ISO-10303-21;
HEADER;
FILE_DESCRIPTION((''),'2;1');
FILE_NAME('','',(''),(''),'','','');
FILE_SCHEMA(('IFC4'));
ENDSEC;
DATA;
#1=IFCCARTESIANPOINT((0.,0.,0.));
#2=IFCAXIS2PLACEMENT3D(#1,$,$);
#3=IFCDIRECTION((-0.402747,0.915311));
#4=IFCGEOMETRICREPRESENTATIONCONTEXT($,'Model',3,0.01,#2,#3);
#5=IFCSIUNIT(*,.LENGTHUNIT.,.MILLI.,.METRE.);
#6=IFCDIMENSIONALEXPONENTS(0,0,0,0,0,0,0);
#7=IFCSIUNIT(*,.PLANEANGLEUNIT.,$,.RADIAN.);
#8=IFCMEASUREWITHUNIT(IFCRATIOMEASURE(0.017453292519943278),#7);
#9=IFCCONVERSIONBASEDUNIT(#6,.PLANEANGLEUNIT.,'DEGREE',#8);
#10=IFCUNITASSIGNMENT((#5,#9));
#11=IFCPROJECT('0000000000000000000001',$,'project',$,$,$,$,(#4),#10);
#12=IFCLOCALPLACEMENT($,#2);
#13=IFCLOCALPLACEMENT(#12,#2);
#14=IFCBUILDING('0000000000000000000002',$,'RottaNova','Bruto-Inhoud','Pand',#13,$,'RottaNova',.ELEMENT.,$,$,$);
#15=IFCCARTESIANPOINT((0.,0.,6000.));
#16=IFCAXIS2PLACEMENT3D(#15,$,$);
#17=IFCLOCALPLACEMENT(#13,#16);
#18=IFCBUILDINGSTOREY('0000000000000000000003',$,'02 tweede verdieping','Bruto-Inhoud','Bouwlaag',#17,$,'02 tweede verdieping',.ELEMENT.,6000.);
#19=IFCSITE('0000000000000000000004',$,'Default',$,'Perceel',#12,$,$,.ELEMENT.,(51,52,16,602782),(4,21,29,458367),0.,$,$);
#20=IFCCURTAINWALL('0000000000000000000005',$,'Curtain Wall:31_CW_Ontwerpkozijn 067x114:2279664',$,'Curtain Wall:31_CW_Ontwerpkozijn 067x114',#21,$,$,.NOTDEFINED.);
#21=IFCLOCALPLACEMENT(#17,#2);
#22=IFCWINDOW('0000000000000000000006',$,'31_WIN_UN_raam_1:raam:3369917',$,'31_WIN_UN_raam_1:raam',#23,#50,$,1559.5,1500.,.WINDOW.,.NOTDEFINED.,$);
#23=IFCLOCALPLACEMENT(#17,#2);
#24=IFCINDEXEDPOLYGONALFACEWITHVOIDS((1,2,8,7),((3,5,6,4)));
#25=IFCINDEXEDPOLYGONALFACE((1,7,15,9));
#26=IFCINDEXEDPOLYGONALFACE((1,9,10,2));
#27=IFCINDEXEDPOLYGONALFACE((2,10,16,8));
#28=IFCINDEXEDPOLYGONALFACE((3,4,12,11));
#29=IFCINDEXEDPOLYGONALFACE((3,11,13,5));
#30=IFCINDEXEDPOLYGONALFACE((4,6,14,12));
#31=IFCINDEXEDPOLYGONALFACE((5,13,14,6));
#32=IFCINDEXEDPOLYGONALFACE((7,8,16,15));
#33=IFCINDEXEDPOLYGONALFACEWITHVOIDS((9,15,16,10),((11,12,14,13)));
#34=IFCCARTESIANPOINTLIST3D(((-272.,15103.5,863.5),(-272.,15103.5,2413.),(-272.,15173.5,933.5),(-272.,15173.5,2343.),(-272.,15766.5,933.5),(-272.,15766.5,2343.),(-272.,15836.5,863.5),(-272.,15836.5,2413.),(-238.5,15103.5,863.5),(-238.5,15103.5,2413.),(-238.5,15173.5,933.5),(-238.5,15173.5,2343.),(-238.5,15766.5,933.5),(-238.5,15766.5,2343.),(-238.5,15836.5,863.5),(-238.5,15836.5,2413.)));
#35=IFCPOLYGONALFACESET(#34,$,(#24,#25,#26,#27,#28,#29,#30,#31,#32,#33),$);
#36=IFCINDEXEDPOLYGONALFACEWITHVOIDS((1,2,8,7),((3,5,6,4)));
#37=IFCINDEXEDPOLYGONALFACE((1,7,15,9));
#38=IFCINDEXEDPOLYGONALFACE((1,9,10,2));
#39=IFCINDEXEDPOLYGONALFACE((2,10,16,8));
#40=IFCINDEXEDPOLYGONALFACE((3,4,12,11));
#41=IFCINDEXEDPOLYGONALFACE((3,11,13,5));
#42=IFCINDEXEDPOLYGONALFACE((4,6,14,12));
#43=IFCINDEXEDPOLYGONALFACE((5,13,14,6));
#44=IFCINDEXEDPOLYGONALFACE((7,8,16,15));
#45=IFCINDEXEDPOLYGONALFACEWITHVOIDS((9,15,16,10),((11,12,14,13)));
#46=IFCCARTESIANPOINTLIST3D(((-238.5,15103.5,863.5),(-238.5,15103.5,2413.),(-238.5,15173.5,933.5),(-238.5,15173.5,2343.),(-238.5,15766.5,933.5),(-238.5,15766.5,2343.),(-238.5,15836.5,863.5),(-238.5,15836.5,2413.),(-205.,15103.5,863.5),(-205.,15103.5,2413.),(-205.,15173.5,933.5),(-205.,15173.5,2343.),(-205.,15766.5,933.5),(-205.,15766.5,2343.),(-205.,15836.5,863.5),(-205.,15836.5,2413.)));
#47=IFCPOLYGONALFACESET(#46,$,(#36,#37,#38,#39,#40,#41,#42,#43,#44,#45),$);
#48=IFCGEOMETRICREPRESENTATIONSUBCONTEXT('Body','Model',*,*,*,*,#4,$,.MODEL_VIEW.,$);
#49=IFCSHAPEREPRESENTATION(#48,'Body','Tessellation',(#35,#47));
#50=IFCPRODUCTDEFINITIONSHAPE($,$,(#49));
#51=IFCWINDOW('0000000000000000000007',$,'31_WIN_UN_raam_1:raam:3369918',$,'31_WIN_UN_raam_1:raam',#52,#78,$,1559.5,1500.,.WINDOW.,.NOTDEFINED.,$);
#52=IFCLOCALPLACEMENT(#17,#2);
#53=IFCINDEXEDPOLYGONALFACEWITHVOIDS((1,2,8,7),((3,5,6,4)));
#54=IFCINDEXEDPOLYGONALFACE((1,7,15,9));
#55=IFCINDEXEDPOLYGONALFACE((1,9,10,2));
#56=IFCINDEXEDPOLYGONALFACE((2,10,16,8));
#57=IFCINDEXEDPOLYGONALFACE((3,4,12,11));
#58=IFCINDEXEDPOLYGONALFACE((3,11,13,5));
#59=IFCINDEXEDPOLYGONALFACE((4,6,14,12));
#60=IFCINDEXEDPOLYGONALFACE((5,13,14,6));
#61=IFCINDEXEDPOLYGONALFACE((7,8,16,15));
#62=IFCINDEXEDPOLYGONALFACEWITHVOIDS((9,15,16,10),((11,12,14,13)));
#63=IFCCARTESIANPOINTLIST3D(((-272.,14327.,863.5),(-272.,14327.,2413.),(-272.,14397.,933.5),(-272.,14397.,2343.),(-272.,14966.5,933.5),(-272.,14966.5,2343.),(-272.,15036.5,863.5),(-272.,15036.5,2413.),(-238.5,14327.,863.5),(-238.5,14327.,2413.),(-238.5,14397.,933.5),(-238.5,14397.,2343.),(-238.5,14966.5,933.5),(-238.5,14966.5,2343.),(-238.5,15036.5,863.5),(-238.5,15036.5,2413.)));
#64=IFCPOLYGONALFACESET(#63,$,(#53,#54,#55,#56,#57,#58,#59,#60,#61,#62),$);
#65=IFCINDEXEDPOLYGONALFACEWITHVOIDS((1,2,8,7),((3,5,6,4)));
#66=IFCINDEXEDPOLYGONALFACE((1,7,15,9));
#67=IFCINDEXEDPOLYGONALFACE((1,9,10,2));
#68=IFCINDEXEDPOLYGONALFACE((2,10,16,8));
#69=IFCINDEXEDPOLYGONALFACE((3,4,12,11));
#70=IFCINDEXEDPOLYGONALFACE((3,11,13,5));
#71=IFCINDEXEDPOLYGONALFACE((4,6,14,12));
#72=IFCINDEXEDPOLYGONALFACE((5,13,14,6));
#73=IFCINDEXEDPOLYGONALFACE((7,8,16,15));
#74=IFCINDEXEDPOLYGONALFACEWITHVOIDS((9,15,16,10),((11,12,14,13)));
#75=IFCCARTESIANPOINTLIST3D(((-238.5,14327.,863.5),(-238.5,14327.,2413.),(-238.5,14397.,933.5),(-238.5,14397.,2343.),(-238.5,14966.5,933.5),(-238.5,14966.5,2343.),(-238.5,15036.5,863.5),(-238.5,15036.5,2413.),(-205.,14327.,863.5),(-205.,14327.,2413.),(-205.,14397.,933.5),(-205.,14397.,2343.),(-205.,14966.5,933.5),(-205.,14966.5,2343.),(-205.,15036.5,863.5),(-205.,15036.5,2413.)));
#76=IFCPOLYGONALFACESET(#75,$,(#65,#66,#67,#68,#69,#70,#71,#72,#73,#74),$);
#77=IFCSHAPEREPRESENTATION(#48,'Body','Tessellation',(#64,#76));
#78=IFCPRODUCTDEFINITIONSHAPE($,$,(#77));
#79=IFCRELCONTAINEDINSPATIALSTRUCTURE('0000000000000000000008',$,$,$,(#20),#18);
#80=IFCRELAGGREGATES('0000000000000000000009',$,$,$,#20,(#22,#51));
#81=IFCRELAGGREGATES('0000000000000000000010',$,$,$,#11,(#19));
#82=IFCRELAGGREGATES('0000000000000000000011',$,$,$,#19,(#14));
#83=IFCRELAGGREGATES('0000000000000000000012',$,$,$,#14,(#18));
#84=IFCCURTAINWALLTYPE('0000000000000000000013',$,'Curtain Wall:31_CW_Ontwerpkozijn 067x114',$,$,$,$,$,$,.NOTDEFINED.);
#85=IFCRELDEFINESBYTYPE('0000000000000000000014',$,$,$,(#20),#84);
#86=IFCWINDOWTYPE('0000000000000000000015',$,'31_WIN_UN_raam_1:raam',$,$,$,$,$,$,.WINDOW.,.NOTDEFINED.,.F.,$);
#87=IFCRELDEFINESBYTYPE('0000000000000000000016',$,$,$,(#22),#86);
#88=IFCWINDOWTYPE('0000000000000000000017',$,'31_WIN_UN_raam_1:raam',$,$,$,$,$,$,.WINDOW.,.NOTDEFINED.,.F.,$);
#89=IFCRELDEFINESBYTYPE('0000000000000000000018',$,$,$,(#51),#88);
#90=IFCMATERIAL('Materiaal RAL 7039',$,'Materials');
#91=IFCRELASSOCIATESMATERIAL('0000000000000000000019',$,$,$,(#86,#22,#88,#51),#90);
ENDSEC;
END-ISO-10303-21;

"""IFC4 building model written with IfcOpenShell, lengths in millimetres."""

from ifc_helpers import new_model, entity, si_unit, converted_unit, direction, frame, origin, place, context, subcontext, project, spatial, polyline, outline, extrude, source, transform, mapped, material, type_object, type_shapes, element, aggregate, save


model = new_model("IFC4")

# Units and contexts
model_context = context("Model", 3, precision=0.01, world=origin(), true_north=direction((-0.402747, 0.915311)))
body_context = subcontext(model_context, "Body", "Model", "MODEL_VIEW")
ifc_project = project(units=[si_unit("LENGTHUNIT", "METRE", prefix="MILLI"), converted_unit("PLANEANGLEUNIT", "DEGREE", entity("IfcRatioMeasure", 0.017453292519943278), si_unit("PLANEANGLEUNIT", "RADIAN"), dimensions=[0, 0, 0, 0, 0, 0, 0])], contexts=[model_context])

# Site, building, storey
site_placement = place(None, origin())
site = spatial("IfcSite", under=ifc_project, at=site_placement, Name="Default", ObjectType="Perceel", CompositionType="ELEMENT", RefLatitude=(51, 52, 16, 602782), RefLongitude=(4, 21, 29, 458367), RefElevation=0.0)
building_placement = place(site_placement, origin())
building = spatial("IfcBuilding", under=site, at=building_placement, Name="RottaNova", Description="Bruto-Inhoud", ObjectType="Pand", LongName="RottaNova", CompositionType="ELEMENT")
storey_placement = place(building_placement, frame((0.0, 0.0, 6000.0)))
storey = spatial("IfcBuildingStorey", under=building, at=storey_placement, Name="02 tweede verdieping", Description="Bruto-Inhoud", ObjectType="Bouwlaag", LongName="02 tweede verdieping", CompositionType="ELEMENT", Elevation=6000.0)

# Curtain wall
curtain_wall_type = type_object("IfcCurtainWallType", Name="Curtain Wall:31_CW_Ontwerpkozijn 067x114", PredefinedType="NOTDEFINED")
curtain_wall_placement = place(storey_placement, frame((0.0, 0.0, -6000.0)))
curtain_wall = element("IfcCurtainWall", 1, at=curtain_wall_placement, inside=storey, type_object=curtain_wall_type, Name="Curtain Wall:31_CW_Ontwerpkozijn 067x114:2279664", ObjectType="Curtain Wall:31_CW_Ontwerpkozijn 067x114", PredefinedType="NOTDEFINED")

# Windows
ifc_material_1 = material(Name="Materiaal RAL 7039", Category="Materials")
window_type_1 = type_object("IfcWindowType", Name="31_WIN_UN_raam_1:raam", ParameterTakesPrecedence=False, PartitioningType="NOTDEFINED", PredefinedType="WINDOW", material=ifc_material_1)
shared_shape_1 = source(origin(), body_context, "Body", "SweptSolid", [
    extrude(outline(polyline([(-366.5, -774.7), (366.5, -774.7), (366.5, 774.7), (-366.5, 774.7), (-366.5, -774.7)]), holes=[polyline([(-296.5, 704.7), (296.5, 704.7), (296.5, -704.8), (-296.5, -704.8), (-296.5, 704.7)])]), frame((0.0, 92.0, 774.8), z_axis=(0.0, -1.0, 0.0), x_axis=(-1.0, 0.0, 0.0)), (0.0, 0.0, 1.0), 33.5),
    extrude(outline(polyline([(-366.5, -774.7), (366.5, -774.7), (366.5, 774.7), (-366.5, 774.7), (-366.5, -774.7)]), holes=[polyline([(-296.5, 704.7), (296.5, 704.7), (296.5, -704.8), (-296.5, -704.8), (-296.5, 704.7)])]), frame((0.0, 58.5, 774.8), z_axis=(0.0, -1.0, 0.0), x_axis=(-1.0, 0.0, 0.0)), (0.0, 0.0, 1.0), 33.5),
])
type_shapes(window_type_1, [shared_shape_1])
window_1_placement = place(curtain_wall_placement, frame((-180.0, 15470.0, 6863.5), z_axis=(0.0, 0.0, 1.0), x_axis=(0.0, 1.0, 0.0)))
window_1 = element("IfcWindow", 2, at=window_1_placement, type_object=window_type_1, material=ifc_material_1, Name="31_WIN_UN_raam_1:raam:3369917", ObjectType="31_WIN_UN_raam_1:raam", OverallHeight=1559.5, OverallWidth=1500.0, PartitioningType="NOTDEFINED", PredefinedType="WINDOW", context=body_context, shape_type="MappedRepresentation", body=[
    mapped(shared_shape_1, transform((0.0, 0.0, 0.0), scale=1.0)),
])
window_type_2 = type_object("IfcWindowType", Name="31_WIN_UN_raam_1:raam", ParameterTakesPrecedence=False, PartitioningType="NOTDEFINED", PredefinedType="WINDOW", material=ifc_material_1)
shared_shape_2 = source(origin(), body_context, "Body", "SweptSolid", [
    extrude(outline(polyline([(-354.7, -774.7), (354.7, -774.7), (354.7, 774.7), (-354.7, 774.7), (-354.7, -774.7)]), holes=[polyline([(-284.7, 704.7), (284.7, 704.7), (284.7, -704.8), (-284.7, -704.8), (-284.7, 704.7)])]), frame((0.0, 92.0, 774.8), z_axis=(0.0, -1.0, 0.0), x_axis=(-1.0, 0.0, 0.0)), (0.0, 0.0, 1.0), 33.5),
    extrude(outline(polyline([(-354.7, -774.7), (354.7, -774.7), (354.7, 774.7), (-354.7, 774.7), (-354.7, -774.7)]), holes=[polyline([(-284.7, 704.7), (284.7, 704.7), (284.7, -704.8), (-284.7, -704.8), (-284.7, 704.7)])]), frame((0.0, 58.5, 774.8), z_axis=(0.0, -1.0, 0.0), x_axis=(-1.0, 0.0, 0.0)), (0.0, 0.0, 1.0), 33.5),
])
type_shapes(window_type_2, [shared_shape_2])
window_2_placement = place(curtain_wall_placement, frame((-180.0, 14681.8, 6863.5), z_axis=(0.0, 0.0, 1.0), x_axis=(0.0, 1.0, 0.0)))
window_2 = element("IfcWindow", 3, at=window_2_placement, type_object=window_type_2, material=ifc_material_1, Name="31_WIN_UN_raam_1:raam:3369918", ObjectType="31_WIN_UN_raam_1:raam", OverallHeight=1559.5, OverallWidth=1500.0, PartitioningType="NOTDEFINED", PredefinedType="WINDOW", context=body_context, shape_type="MappedRepresentation", body=[
    mapped(shared_shape_2, transform((0.0, 0.0, 0.0), scale=1.0)),
])
aggregate(curtain_wall, [window_1, window_2])

save(model, "model.ifc")
